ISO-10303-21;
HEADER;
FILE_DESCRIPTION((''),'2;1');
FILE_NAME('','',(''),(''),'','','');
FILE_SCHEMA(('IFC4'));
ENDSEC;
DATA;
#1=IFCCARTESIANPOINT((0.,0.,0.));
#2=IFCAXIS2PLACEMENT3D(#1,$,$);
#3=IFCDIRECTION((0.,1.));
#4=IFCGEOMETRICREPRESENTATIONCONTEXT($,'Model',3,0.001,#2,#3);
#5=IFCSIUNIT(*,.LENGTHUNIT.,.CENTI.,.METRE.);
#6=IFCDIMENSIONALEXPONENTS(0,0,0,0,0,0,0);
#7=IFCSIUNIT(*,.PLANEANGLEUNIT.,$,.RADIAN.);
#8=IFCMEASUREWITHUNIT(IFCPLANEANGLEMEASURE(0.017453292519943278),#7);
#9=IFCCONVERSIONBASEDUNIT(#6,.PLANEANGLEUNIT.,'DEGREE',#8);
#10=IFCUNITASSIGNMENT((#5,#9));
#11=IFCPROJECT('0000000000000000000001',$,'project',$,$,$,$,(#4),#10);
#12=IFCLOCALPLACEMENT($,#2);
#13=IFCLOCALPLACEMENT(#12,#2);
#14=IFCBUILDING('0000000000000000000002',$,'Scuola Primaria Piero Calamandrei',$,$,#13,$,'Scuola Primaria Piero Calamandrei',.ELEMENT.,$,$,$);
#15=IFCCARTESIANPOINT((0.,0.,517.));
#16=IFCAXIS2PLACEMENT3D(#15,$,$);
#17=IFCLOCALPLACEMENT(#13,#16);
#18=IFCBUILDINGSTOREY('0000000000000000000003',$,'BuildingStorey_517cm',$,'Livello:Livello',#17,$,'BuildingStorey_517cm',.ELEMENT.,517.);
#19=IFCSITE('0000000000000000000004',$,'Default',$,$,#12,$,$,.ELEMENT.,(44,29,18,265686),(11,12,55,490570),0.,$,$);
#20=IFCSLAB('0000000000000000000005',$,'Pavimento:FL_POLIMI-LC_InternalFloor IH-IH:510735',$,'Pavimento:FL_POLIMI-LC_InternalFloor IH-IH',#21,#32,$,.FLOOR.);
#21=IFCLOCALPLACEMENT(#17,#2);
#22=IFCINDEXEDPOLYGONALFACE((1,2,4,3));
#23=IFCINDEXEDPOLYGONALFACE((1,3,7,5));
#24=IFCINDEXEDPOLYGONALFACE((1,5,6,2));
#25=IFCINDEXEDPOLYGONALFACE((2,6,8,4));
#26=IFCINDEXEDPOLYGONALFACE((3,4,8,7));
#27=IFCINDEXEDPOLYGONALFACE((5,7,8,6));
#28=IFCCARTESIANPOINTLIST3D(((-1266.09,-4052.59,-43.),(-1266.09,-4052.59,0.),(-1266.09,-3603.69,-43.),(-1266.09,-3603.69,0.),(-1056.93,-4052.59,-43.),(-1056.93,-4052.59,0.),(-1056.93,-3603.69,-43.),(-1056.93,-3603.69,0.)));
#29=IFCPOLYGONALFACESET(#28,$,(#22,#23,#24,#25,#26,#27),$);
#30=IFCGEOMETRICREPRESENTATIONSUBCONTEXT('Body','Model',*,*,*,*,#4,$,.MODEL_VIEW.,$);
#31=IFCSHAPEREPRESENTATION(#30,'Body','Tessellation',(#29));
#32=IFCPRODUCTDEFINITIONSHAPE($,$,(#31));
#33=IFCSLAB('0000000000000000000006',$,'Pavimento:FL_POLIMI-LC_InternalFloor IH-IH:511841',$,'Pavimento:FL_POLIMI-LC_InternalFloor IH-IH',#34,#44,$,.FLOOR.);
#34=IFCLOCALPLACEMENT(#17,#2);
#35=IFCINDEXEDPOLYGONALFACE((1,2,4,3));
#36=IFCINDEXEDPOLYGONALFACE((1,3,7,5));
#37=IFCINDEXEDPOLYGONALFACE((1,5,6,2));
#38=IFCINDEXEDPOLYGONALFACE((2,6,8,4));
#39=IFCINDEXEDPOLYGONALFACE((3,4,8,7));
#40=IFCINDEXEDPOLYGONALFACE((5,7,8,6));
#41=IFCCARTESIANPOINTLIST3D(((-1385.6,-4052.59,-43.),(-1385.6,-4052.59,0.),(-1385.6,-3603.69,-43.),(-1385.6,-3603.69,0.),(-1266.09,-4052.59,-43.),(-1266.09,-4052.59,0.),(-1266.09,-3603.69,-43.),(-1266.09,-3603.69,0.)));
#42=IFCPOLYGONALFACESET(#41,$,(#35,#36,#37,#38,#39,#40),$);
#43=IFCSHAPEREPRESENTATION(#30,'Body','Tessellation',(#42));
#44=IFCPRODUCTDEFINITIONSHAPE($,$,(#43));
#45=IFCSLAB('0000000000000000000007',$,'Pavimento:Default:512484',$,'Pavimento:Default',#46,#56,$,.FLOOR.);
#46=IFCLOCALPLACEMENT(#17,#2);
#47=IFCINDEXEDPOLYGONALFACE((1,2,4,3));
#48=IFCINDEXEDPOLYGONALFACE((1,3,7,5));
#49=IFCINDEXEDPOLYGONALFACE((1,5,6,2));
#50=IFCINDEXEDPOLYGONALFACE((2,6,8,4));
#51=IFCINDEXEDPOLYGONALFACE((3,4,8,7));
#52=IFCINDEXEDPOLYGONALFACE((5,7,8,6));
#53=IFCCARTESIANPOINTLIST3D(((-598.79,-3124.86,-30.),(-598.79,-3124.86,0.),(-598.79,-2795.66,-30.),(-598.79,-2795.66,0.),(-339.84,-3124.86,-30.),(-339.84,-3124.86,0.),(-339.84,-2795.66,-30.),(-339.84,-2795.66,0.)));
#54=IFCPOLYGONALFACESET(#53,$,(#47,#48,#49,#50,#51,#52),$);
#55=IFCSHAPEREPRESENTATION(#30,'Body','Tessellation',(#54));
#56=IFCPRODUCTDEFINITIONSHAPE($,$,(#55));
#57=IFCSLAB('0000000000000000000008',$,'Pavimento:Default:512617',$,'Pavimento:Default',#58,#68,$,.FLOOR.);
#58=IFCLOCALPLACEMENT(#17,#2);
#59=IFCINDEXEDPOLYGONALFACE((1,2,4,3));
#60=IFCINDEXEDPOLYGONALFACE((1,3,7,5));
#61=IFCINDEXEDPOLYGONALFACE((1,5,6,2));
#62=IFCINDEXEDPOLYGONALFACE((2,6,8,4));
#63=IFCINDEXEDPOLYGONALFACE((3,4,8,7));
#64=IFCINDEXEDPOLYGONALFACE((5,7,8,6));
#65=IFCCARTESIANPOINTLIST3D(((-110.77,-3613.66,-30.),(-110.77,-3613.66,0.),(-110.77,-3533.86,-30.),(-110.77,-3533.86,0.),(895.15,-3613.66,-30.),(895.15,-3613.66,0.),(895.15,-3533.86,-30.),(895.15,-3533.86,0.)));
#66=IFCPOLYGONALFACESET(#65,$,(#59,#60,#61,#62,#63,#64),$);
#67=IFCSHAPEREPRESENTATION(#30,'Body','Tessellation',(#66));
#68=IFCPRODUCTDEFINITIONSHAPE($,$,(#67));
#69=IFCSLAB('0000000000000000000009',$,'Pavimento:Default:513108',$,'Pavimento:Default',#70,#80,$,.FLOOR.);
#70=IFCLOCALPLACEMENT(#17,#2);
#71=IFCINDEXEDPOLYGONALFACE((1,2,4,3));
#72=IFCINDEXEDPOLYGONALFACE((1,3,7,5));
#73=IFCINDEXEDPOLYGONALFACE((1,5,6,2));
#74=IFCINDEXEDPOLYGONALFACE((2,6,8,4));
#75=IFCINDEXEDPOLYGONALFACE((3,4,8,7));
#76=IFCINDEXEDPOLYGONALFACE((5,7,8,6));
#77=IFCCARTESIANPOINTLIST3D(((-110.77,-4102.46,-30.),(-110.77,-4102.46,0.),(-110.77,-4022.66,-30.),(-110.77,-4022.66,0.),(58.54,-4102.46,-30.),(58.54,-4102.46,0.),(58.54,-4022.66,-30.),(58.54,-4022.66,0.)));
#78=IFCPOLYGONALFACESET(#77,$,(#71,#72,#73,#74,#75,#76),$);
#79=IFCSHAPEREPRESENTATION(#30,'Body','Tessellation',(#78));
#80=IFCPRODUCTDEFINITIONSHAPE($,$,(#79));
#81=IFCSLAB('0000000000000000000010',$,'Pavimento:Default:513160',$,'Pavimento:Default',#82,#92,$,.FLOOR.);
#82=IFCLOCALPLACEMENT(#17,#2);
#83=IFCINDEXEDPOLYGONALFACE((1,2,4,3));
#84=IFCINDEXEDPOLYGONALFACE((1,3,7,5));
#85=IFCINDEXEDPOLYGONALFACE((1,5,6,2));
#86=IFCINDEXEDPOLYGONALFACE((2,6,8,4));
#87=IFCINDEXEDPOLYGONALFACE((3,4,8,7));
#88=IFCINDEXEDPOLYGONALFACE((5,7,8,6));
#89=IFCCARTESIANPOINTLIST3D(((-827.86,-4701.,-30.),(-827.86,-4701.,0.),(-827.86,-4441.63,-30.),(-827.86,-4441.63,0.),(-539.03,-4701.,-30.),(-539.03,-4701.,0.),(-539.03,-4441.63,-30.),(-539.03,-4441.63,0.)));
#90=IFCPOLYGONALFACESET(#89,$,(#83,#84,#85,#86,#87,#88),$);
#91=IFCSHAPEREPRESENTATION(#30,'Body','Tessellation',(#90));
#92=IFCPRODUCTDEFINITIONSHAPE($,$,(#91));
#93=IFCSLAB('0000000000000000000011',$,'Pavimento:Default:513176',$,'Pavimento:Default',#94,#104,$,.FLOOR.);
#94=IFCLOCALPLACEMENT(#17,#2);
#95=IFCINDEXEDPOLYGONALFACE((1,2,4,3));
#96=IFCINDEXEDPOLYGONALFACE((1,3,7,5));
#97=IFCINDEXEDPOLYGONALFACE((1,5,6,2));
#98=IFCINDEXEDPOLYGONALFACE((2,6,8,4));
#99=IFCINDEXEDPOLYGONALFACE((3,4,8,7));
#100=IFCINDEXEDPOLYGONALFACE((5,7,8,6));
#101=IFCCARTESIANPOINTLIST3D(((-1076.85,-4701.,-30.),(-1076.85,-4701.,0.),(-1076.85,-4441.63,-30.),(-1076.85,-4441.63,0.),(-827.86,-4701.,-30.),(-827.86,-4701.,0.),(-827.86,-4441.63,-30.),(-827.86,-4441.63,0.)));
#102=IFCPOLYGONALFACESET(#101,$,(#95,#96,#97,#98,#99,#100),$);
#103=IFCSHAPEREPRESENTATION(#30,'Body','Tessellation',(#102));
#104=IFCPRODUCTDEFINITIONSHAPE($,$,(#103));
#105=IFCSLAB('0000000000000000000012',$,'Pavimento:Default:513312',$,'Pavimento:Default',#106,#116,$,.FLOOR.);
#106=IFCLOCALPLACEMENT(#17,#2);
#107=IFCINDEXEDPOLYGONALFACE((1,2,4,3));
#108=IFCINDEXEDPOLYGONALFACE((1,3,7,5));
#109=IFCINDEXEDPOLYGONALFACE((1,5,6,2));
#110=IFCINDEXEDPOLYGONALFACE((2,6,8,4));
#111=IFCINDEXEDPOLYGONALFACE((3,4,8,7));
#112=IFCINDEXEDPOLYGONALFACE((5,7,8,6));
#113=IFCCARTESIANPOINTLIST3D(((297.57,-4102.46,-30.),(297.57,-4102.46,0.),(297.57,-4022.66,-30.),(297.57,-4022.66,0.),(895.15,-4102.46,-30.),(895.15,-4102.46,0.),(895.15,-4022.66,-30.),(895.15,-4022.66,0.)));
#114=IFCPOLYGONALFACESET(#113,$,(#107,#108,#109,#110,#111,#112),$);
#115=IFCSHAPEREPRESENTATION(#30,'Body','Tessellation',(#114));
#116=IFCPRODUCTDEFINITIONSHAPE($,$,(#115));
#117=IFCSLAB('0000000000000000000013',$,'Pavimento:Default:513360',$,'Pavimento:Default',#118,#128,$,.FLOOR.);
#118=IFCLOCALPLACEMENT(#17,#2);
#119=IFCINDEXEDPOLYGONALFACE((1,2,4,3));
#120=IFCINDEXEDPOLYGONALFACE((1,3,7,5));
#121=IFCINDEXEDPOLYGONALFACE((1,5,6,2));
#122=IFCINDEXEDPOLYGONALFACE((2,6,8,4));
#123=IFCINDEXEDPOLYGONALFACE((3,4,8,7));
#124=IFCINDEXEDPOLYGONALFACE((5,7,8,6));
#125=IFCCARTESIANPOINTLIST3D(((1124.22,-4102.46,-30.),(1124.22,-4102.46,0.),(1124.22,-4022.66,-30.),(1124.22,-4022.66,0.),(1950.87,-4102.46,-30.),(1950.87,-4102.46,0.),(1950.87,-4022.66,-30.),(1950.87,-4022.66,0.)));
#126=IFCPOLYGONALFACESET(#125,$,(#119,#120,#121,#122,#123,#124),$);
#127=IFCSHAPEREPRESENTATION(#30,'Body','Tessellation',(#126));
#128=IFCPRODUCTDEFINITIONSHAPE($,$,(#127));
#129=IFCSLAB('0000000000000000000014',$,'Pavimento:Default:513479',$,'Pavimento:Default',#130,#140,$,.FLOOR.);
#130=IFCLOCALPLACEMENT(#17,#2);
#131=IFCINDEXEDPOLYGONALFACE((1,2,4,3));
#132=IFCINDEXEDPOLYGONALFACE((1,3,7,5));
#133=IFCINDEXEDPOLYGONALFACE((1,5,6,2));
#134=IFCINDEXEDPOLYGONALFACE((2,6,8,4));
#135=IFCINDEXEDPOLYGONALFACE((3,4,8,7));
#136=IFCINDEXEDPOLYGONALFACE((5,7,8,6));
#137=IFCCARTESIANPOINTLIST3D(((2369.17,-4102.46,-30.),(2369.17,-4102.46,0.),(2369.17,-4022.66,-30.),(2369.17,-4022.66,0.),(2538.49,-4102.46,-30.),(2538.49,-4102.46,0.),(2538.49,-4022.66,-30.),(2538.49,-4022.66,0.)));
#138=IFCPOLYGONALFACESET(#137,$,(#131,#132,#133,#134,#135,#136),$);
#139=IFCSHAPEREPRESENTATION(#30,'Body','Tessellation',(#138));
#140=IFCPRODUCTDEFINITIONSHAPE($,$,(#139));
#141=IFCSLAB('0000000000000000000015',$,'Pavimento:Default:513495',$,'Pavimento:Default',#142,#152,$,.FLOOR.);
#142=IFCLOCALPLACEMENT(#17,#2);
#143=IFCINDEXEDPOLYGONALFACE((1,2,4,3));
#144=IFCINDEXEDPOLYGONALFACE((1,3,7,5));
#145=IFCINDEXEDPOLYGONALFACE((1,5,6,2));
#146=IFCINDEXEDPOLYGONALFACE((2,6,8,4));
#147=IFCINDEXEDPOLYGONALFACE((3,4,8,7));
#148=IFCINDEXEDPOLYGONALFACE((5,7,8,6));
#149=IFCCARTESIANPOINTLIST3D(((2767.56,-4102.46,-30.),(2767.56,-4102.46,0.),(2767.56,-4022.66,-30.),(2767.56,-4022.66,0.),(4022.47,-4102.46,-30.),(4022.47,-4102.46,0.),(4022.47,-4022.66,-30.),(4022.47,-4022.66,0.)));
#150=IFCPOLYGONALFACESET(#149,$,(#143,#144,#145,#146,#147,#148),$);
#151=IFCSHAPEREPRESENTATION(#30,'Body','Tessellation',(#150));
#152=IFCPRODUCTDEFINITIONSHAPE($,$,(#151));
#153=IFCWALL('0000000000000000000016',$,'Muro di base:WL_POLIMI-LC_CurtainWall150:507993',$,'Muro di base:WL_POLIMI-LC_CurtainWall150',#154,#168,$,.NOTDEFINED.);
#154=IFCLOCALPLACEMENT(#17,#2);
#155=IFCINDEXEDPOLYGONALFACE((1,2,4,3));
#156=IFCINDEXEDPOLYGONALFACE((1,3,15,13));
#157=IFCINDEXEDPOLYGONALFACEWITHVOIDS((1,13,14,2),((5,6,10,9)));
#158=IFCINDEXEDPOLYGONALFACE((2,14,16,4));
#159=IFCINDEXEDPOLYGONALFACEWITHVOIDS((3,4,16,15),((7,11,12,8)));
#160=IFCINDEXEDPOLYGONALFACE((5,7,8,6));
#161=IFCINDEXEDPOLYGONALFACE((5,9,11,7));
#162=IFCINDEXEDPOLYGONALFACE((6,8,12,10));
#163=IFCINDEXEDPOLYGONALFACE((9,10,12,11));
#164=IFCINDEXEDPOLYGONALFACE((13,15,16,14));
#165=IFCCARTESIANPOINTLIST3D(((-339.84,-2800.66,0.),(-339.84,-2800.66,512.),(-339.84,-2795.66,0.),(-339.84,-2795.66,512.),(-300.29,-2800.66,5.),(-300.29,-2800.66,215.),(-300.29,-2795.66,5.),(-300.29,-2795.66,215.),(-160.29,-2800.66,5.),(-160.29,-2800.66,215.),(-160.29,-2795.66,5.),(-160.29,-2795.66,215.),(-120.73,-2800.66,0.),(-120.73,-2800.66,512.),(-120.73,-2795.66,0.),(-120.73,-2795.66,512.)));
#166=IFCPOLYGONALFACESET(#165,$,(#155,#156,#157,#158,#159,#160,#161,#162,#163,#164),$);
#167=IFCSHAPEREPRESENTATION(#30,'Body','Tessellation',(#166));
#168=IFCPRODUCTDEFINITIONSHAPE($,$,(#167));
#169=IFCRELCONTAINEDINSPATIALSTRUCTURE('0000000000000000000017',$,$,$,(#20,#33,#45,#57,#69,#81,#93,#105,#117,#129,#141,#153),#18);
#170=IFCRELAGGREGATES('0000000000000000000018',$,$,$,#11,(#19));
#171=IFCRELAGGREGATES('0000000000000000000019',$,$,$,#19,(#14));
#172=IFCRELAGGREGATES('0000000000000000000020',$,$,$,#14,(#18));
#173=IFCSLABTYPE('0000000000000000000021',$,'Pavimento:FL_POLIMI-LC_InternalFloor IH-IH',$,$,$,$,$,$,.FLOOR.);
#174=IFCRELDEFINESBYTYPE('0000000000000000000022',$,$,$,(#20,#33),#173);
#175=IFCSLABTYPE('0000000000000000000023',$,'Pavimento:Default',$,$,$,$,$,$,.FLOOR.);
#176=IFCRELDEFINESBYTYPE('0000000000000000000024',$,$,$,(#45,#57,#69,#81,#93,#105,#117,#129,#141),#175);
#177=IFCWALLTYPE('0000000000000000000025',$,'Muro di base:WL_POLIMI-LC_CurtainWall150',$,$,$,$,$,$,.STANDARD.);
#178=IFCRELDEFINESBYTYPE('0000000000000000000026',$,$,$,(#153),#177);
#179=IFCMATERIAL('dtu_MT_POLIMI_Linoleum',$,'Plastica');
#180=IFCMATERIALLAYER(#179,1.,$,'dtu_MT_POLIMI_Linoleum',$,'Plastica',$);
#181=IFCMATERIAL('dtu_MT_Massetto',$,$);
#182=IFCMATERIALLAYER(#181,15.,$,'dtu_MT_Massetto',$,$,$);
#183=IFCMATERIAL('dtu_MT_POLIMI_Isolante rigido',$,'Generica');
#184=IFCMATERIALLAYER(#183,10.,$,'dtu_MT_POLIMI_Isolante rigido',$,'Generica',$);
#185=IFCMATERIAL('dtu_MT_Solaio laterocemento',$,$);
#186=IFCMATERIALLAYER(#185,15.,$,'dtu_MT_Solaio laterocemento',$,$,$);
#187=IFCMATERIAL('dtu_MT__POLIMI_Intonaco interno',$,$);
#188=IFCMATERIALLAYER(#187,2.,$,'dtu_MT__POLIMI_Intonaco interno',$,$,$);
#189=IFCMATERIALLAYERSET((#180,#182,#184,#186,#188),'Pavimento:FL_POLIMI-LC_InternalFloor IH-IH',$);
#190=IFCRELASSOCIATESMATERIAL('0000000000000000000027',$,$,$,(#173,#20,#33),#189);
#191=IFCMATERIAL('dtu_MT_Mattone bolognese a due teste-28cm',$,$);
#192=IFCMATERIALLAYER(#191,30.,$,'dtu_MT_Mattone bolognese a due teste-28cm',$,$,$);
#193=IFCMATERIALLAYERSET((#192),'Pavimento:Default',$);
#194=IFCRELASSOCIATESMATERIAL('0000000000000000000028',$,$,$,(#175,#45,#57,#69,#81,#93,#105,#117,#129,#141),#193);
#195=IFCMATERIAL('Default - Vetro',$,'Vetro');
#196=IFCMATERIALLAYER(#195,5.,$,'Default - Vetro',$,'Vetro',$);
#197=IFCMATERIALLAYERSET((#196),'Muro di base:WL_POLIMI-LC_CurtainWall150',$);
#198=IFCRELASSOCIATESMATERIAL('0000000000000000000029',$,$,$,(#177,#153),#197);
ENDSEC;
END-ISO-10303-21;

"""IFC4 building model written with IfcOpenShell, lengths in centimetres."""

from ifc_helpers import new_model, entity, si_unit, converted_unit, direction, frame, frame_2d, origin, origin_2d_with_axis, place, context, subcontext, project, spatial, rectangle, extrude, material, layer, layer_set, layer_usage, type_object, element, save


model = new_model("IFC4")

# Units and contexts
model_context = context("Model", 3, precision=0.001, world=origin(), true_north=direction((0.0, 1.0)))
body_context = subcontext(model_context, "Body", "Model", "MODEL_VIEW")
ifc_project = project(units=[si_unit("LENGTHUNIT", "METRE", prefix="CENTI"), converted_unit("PLANEANGLEUNIT", "DEGREE", entity("IfcPlaneAngleMeasure", 0.017453292519943278), si_unit("PLANEANGLEUNIT", "RADIAN"), dimensions=[0, 0, 0, 0, 0, 0, 0])], contexts=[model_context])

# Site, building, storey
site_placement = place(None, origin())
site = spatial("IfcSite", under=ifc_project, at=site_placement, Name="Default", CompositionType="ELEMENT", RefLatitude=(44, 29, 18, 265686), RefLongitude=(11, 12, 55, 490570), RefElevation=0.0)
building_placement = place(site_placement, origin())
building = spatial("IfcBuilding", under=site, at=building_placement, Name="Scuola Primaria Piero Calamandrei", LongName="Scuola Primaria Piero Calamandrei", CompositionType="ELEMENT")
storey_placement = place(building_placement, frame((0.0, 0.0, 517.0)))
storey = spatial("IfcBuildingStorey", under=building, at=storey_placement, Name="BuildingStorey_517cm", ObjectType="Livello:Livello", LongName="BuildingStorey_517cm", CompositionType="ELEMENT", Elevation=517.0)

# Slabs
ifc_material_1 = material(Name="dtu_MT_POLIMI_Linoleum", Category="Plastica")
ifc_layer_1 = layer(ifc_material_1, 1.0, Name="dtu_MT_POLIMI_Linoleum", Category="Plastica")
ifc_material_2 = material(Name="dtu_MT_Massetto")
ifc_layer_2 = layer(ifc_material_2, 15.0, Name="dtu_MT_Massetto")
ifc_material_3 = material(Name="dtu_MT_POLIMI_Isolante rigido", Category="Generica")
ifc_layer_3 = layer(ifc_material_3, 10.0, Name="dtu_MT_POLIMI_Isolante rigido", Category="Generica")
ifc_material_4 = material(Name="dtu_MT_Solaio laterocemento")
ifc_layer_4 = layer(ifc_material_4, 15.0, Name="dtu_MT_Solaio laterocemento")
ifc_material_5 = material(Name="dtu_MT__POLIMI_Intonaco interno")
ifc_layer_5 = layer(ifc_material_5, 2.0, Name="dtu_MT__POLIMI_Intonaco interno")
ifc_layer_set_1 = layer_set([ifc_layer_1, ifc_layer_2, ifc_layer_3, ifc_layer_4, ifc_layer_5], Name="Pavimento:FL_POLIMI-LC_InternalFloor IH-IH")
ifc_layer_usage_1 = layer_usage(ifc_layer_set_1, "AXIS3", "POSITIVE", 0.0)
slab_type_1 = type_object("IfcSlabType", Name="Pavimento:FL_POLIMI-LC_InternalFloor IH-IH", PredefinedType="FLOOR", material=ifc_layer_set_1)
slab_1_placement = place(storey_placement, origin())
element("IfcSlab", 1, at=slab_1_placement, inside=storey, type_object=slab_type_1, material=ifc_layer_usage_1, Name="Pavimento:FL_POLIMI-LC_InternalFloor IH-IH:510735", ObjectType="Pavimento:FL_POLIMI-LC_InternalFloor IH-IH", PredefinedType="FLOOR", context=body_context, shape_type="SweptSolid", body=[
    extrude(rectangle(XDim=448.9, YDim=209.15, at=frame_2d((0.0, 0.0), x_axis=(1.0, 0.0))), frame((-1161.51, -3828.14, 0.0), z_axis=(0.0, 0.0, -1.0), x_axis=(0.0, 1.0, 0.0)), (0.0, 0.0, 1.0), 43.0),
])
ifc_layer_usage_2 = layer_usage(ifc_layer_set_1, "AXIS3", "POSITIVE", 0.0)
slab_2_placement = place(storey_placement, origin())
element("IfcSlab", 2, at=slab_2_placement, inside=storey, type_object=slab_type_1, material=ifc_layer_usage_2, Name="Pavimento:FL_POLIMI-LC_InternalFloor IH-IH:511841", ObjectType="Pavimento:FL_POLIMI-LC_InternalFloor IH-IH", PredefinedType="FLOOR", context=body_context, shape_type="SweptSolid", body=[
    extrude(rectangle(XDim=448.9, YDim=119.52, at=frame_2d((0.0, 0.0), x_axis=(1.0, 0.0))), frame((-1325.84, -3828.14, 0.0), z_axis=(0.0, 0.0, -1.0), x_axis=(0.0, 1.0, 0.0)), (0.0, 0.0, 1.0), 43.0),
])
ifc_material_6 = material(Name="dtu_MT_Mattone bolognese a due teste-28cm")
ifc_layer_6 = layer(ifc_material_6, 30.0, Name="dtu_MT_Mattone bolognese a due teste-28cm")
ifc_layer_set_2 = layer_set([ifc_layer_6], Name="Pavimento:Default")
slab_type_2 = type_object("IfcSlabType", Name="Pavimento:Default", PredefinedType="FLOOR", material=ifc_layer_set_2)
ifc_layer_usage_3 = layer_usage(ifc_layer_set_2, "AXIS3", "POSITIVE", 0.0)
slab_3_placement = place(storey_placement, origin())
element("IfcSlab", 3, at=slab_3_placement, inside=storey, type_object=slab_type_2, material=ifc_layer_usage_3, Name="Pavimento:Default:512484", ObjectType="Pavimento:Default", PredefinedType="FLOOR", context=body_context, shape_type="SweptSolid", body=[
    extrude(rectangle(XDim=329.19, YDim=258.95, at=frame_2d((0.0, 0.0), x_axis=(1.0, 0.0))), frame((-469.32, -2960.26, 0.0), z_axis=(0.0, 0.0, -1.0), x_axis=(0.0, 1.0, 0.0)), (0.0, 0.0, 1.0), 30.0),
])
ifc_layer_usage_4 = layer_usage(ifc_layer_set_2, "AXIS3", "POSITIVE", 0.0)
slab_4_placement = place(storey_placement, origin())
element("IfcSlab", 4, at=slab_4_placement, inside=storey, type_object=slab_type_2, material=ifc_layer_usage_4, Name="Pavimento:Default:512617", ObjectType="Pavimento:Default", PredefinedType="FLOOR", context=body_context, shape_type="SweptSolid", body=[
    extrude(rectangle(XDim=79.8, YDim=1005.92, at=origin_2d_with_axis()), frame((392.19, -3573.76, 0.0), z_axis=(0.0, 0.0, -1.0), x_axis=(0.0, 1.0, 0.0)), (0.0, 0.0, 1.0), 30.0),
])
ifc_layer_usage_5 = layer_usage(ifc_layer_set_2, "AXIS3", "POSITIVE", 0.0)
slab_5_placement = place(storey_placement, origin())
element("IfcSlab", 5, at=slab_5_placement, inside=storey, type_object=slab_type_2, material=ifc_layer_usage_5, Name="Pavimento:Default:513108", ObjectType="Pavimento:Default", PredefinedType="FLOOR", context=body_context, shape_type="SweptSolid", body=[
    extrude(rectangle(XDim=79.8, YDim=169.31, at=frame_2d((0.0, 0.0), x_axis=(1.0, 0.0))), frame((-26.11, -4062.56, 0.0), z_axis=(0.0, 0.0, -1.0), x_axis=(0.0, 1.0, 0.0)), (0.0, 0.0, 1.0), 30.0),
])
ifc_layer_usage_6 = layer_usage(ifc_layer_set_2, "AXIS3", "POSITIVE", 0.0)
slab_6_placement = place(storey_placement, origin())
element("IfcSlab", 6, at=slab_6_placement, inside=storey, type_object=slab_type_2, material=ifc_layer_usage_6, Name="Pavimento:Default:513160", ObjectType="Pavimento:Default", PredefinedType="FLOOR", context=body_context, shape_type="SweptSolid", body=[
    extrude(rectangle(XDim=259.36, YDim=288.83, at=frame_2d((0.0, 0.0), x_axis=(1.0, 0.0))), frame((-683.45, -4571.31, 0.0), z_axis=(0.0, 0.0, -1.0), x_axis=(0.0, 1.0, 0.0)), (0.0, 0.0, 1.0), 30.0),
])
ifc_layer_usage_7 = layer_usage(ifc_layer_set_2, "AXIS3", "POSITIVE", 0.0)
slab_7_placement = place(storey_placement, origin())
element("IfcSlab", 7, at=slab_7_placement, inside=storey, type_object=slab_type_2, material=ifc_layer_usage_7, Name="Pavimento:Default:513176", ObjectType="Pavimento:Default", PredefinedType="FLOOR", context=body_context, shape_type="SweptSolid", body=[
    extrude(rectangle(XDim=259.36, YDim=248.99, at=frame_2d((0.0, 0.0), x_axis=(1.0, 0.0))), frame((-952.36, -4571.31, 0.0), z_axis=(0.0, 0.0, -1.0), x_axis=(0.0, 1.0, 0.0)), (0.0, 0.0, 1.0), 30.0),
])
ifc_layer_usage_8 = layer_usage(ifc_layer_set_2, "AXIS3", "POSITIVE", 0.0)
slab_8_placement = place(storey_placement, origin())
element("IfcSlab", 8, at=slab_8_placement, inside=storey, type_object=slab_type_2, material=ifc_layer_usage_8, Name="Pavimento:Default:513312", ObjectType="Pavimento:Default", PredefinedType="FLOOR", context=body_context, shape_type="SweptSolid", body=[
    extrude(rectangle(XDim=79.8, YDim=597.58, at=frame_2d((0.0, 0.0), x_axis=(1.0, 0.0))), frame((596.36, -4062.56, 0.0), z_axis=(0.0, 0.0, -1.0), x_axis=(0.0, 1.0, 0.0)), (0.0, 0.0, 1.0), 30.0),
])
ifc_layer_usage_9 = layer_usage(ifc_layer_set_2, "AXIS3", "POSITIVE", 0.0)
slab_9_placement = place(storey_placement, origin())
element("IfcSlab", 9, at=slab_9_placement, inside=storey, type_object=slab_type_2, material=ifc_layer_usage_9, Name="Pavimento:Default:513360", ObjectType="Pavimento:Default", PredefinedType="FLOOR", context=body_context, shape_type="SweptSolid", body=[
    extrude(rectangle(XDim=79.8, YDim=826.65, at=frame_2d((0.0, 0.0), x_axis=(1.0, 0.0))), frame((1537.55, -4062.56, 0.0), z_axis=(0.0, 0.0, -1.0), x_axis=(0.0, 1.0, 0.0)), (0.0, 0.0, 1.0), 30.0),
])
ifc_layer_usage_10 = layer_usage(ifc_layer_set_2, "AXIS3", "POSITIVE", 0.0)
slab_10_placement = place(storey_placement, origin())
element("IfcSlab", 10, at=slab_10_placement, inside=storey, type_object=slab_type_2, material=ifc_layer_usage_10, Name="Pavimento:Default:513479", ObjectType="Pavimento:Default", PredefinedType="FLOOR", context=body_context, shape_type="SweptSolid", body=[
    extrude(rectangle(XDim=79.8, YDim=169.31, at=frame_2d((0.0, 0.0), x_axis=(1.0, 0.0))), frame((2453.83, -4062.56, 0.0), z_axis=(0.0, 0.0, -1.0), x_axis=(0.0, 1.0, 0.0)), (0.0, 0.0, 1.0), 30.0),
])
ifc_layer_usage_11 = layer_usage(ifc_layer_set_2, "AXIS3", "POSITIVE", 0.0)
slab_11_placement = place(storey_placement, origin())
element("IfcSlab", 11, at=slab_11_placement, inside=storey, type_object=slab_type_2, material=ifc_layer_usage_11, Name="Pavimento:Default:513495", ObjectType="Pavimento:Default", PredefinedType="FLOOR", context=body_context, shape_type="SweptSolid", body=[
    extrude(rectangle(XDim=79.8, YDim=1254.91, at=frame_2d((0.0, 0.0), x_axis=(1.0, 0.0))), frame((3395.02, -4062.56, 0.0), z_axis=(0.0, 0.0, -1.0), x_axis=(0.0, 1.0, 0.0)), (0.0, 0.0, 1.0), 30.0),
])

# Wall, opening
ifc_material_7 = material(Name="Default - Vetro", Category="Vetro")
ifc_layer_7 = layer(ifc_material_7, 5.0, Name="Default - Vetro", Category="Vetro")
ifc_layer_set_3 = layer_set([ifc_layer_7], Name="Muro di base:WL_POLIMI-LC_CurtainWall150")
ifc_layer_usage_12 = layer_usage(ifc_layer_set_3, "AXIS2", "NEGATIVE", 2.5)
wall_type_1 = type_object("IfcWallType", Name="Muro di base:WL_POLIMI-LC_CurtainWall150", PredefinedType="STANDARD", material=ifc_layer_set_3)
wall_1_placement = place(storey_placement, frame((-339.84, -2798.16, 0.0)))
wall_1 = element("IfcWall", 12, at=wall_1_placement, inside=storey, type_object=wall_type_1, material=ifc_layer_usage_12, Name="Muro di base:WL_POLIMI-LC_CurtainWall150:507993", ObjectType="Muro di base:WL_POLIMI-LC_CurtainWall150", PredefinedType="NOTDEFINED", context=body_context, shape_type="SweptSolid", body=[
    extrude(rectangle(XDim=219.11, YDim=5.0, at=frame_2d((109.56, 0.0), x_axis=(-1.0, 0.0))), origin(), (0.0, 0.0, 1.0), 512.0),
])
opening_1_placement = place(wall_1_placement, frame((179.56, 2.5, 5.0)))
element("IfcOpeningElement", 13, at=opening_1_placement, cuts=wall_1, PredefinedType="OPENING", context=body_context, shape_type="SweptSolid", body=[
    extrude(rectangle(XDim=210.0, YDim=140.0, at=frame_2d((105.0, 70.0), x_axis=(1.0, 0.0))), frame((0.0, 0.0, 0.0), z_axis=(0.0, -1.0, 0.0), x_axis=(0.0, 0.0, 1.0)), (0.0, 0.0, 1.0), 5.0),
])

save(model, "model.ifc")
